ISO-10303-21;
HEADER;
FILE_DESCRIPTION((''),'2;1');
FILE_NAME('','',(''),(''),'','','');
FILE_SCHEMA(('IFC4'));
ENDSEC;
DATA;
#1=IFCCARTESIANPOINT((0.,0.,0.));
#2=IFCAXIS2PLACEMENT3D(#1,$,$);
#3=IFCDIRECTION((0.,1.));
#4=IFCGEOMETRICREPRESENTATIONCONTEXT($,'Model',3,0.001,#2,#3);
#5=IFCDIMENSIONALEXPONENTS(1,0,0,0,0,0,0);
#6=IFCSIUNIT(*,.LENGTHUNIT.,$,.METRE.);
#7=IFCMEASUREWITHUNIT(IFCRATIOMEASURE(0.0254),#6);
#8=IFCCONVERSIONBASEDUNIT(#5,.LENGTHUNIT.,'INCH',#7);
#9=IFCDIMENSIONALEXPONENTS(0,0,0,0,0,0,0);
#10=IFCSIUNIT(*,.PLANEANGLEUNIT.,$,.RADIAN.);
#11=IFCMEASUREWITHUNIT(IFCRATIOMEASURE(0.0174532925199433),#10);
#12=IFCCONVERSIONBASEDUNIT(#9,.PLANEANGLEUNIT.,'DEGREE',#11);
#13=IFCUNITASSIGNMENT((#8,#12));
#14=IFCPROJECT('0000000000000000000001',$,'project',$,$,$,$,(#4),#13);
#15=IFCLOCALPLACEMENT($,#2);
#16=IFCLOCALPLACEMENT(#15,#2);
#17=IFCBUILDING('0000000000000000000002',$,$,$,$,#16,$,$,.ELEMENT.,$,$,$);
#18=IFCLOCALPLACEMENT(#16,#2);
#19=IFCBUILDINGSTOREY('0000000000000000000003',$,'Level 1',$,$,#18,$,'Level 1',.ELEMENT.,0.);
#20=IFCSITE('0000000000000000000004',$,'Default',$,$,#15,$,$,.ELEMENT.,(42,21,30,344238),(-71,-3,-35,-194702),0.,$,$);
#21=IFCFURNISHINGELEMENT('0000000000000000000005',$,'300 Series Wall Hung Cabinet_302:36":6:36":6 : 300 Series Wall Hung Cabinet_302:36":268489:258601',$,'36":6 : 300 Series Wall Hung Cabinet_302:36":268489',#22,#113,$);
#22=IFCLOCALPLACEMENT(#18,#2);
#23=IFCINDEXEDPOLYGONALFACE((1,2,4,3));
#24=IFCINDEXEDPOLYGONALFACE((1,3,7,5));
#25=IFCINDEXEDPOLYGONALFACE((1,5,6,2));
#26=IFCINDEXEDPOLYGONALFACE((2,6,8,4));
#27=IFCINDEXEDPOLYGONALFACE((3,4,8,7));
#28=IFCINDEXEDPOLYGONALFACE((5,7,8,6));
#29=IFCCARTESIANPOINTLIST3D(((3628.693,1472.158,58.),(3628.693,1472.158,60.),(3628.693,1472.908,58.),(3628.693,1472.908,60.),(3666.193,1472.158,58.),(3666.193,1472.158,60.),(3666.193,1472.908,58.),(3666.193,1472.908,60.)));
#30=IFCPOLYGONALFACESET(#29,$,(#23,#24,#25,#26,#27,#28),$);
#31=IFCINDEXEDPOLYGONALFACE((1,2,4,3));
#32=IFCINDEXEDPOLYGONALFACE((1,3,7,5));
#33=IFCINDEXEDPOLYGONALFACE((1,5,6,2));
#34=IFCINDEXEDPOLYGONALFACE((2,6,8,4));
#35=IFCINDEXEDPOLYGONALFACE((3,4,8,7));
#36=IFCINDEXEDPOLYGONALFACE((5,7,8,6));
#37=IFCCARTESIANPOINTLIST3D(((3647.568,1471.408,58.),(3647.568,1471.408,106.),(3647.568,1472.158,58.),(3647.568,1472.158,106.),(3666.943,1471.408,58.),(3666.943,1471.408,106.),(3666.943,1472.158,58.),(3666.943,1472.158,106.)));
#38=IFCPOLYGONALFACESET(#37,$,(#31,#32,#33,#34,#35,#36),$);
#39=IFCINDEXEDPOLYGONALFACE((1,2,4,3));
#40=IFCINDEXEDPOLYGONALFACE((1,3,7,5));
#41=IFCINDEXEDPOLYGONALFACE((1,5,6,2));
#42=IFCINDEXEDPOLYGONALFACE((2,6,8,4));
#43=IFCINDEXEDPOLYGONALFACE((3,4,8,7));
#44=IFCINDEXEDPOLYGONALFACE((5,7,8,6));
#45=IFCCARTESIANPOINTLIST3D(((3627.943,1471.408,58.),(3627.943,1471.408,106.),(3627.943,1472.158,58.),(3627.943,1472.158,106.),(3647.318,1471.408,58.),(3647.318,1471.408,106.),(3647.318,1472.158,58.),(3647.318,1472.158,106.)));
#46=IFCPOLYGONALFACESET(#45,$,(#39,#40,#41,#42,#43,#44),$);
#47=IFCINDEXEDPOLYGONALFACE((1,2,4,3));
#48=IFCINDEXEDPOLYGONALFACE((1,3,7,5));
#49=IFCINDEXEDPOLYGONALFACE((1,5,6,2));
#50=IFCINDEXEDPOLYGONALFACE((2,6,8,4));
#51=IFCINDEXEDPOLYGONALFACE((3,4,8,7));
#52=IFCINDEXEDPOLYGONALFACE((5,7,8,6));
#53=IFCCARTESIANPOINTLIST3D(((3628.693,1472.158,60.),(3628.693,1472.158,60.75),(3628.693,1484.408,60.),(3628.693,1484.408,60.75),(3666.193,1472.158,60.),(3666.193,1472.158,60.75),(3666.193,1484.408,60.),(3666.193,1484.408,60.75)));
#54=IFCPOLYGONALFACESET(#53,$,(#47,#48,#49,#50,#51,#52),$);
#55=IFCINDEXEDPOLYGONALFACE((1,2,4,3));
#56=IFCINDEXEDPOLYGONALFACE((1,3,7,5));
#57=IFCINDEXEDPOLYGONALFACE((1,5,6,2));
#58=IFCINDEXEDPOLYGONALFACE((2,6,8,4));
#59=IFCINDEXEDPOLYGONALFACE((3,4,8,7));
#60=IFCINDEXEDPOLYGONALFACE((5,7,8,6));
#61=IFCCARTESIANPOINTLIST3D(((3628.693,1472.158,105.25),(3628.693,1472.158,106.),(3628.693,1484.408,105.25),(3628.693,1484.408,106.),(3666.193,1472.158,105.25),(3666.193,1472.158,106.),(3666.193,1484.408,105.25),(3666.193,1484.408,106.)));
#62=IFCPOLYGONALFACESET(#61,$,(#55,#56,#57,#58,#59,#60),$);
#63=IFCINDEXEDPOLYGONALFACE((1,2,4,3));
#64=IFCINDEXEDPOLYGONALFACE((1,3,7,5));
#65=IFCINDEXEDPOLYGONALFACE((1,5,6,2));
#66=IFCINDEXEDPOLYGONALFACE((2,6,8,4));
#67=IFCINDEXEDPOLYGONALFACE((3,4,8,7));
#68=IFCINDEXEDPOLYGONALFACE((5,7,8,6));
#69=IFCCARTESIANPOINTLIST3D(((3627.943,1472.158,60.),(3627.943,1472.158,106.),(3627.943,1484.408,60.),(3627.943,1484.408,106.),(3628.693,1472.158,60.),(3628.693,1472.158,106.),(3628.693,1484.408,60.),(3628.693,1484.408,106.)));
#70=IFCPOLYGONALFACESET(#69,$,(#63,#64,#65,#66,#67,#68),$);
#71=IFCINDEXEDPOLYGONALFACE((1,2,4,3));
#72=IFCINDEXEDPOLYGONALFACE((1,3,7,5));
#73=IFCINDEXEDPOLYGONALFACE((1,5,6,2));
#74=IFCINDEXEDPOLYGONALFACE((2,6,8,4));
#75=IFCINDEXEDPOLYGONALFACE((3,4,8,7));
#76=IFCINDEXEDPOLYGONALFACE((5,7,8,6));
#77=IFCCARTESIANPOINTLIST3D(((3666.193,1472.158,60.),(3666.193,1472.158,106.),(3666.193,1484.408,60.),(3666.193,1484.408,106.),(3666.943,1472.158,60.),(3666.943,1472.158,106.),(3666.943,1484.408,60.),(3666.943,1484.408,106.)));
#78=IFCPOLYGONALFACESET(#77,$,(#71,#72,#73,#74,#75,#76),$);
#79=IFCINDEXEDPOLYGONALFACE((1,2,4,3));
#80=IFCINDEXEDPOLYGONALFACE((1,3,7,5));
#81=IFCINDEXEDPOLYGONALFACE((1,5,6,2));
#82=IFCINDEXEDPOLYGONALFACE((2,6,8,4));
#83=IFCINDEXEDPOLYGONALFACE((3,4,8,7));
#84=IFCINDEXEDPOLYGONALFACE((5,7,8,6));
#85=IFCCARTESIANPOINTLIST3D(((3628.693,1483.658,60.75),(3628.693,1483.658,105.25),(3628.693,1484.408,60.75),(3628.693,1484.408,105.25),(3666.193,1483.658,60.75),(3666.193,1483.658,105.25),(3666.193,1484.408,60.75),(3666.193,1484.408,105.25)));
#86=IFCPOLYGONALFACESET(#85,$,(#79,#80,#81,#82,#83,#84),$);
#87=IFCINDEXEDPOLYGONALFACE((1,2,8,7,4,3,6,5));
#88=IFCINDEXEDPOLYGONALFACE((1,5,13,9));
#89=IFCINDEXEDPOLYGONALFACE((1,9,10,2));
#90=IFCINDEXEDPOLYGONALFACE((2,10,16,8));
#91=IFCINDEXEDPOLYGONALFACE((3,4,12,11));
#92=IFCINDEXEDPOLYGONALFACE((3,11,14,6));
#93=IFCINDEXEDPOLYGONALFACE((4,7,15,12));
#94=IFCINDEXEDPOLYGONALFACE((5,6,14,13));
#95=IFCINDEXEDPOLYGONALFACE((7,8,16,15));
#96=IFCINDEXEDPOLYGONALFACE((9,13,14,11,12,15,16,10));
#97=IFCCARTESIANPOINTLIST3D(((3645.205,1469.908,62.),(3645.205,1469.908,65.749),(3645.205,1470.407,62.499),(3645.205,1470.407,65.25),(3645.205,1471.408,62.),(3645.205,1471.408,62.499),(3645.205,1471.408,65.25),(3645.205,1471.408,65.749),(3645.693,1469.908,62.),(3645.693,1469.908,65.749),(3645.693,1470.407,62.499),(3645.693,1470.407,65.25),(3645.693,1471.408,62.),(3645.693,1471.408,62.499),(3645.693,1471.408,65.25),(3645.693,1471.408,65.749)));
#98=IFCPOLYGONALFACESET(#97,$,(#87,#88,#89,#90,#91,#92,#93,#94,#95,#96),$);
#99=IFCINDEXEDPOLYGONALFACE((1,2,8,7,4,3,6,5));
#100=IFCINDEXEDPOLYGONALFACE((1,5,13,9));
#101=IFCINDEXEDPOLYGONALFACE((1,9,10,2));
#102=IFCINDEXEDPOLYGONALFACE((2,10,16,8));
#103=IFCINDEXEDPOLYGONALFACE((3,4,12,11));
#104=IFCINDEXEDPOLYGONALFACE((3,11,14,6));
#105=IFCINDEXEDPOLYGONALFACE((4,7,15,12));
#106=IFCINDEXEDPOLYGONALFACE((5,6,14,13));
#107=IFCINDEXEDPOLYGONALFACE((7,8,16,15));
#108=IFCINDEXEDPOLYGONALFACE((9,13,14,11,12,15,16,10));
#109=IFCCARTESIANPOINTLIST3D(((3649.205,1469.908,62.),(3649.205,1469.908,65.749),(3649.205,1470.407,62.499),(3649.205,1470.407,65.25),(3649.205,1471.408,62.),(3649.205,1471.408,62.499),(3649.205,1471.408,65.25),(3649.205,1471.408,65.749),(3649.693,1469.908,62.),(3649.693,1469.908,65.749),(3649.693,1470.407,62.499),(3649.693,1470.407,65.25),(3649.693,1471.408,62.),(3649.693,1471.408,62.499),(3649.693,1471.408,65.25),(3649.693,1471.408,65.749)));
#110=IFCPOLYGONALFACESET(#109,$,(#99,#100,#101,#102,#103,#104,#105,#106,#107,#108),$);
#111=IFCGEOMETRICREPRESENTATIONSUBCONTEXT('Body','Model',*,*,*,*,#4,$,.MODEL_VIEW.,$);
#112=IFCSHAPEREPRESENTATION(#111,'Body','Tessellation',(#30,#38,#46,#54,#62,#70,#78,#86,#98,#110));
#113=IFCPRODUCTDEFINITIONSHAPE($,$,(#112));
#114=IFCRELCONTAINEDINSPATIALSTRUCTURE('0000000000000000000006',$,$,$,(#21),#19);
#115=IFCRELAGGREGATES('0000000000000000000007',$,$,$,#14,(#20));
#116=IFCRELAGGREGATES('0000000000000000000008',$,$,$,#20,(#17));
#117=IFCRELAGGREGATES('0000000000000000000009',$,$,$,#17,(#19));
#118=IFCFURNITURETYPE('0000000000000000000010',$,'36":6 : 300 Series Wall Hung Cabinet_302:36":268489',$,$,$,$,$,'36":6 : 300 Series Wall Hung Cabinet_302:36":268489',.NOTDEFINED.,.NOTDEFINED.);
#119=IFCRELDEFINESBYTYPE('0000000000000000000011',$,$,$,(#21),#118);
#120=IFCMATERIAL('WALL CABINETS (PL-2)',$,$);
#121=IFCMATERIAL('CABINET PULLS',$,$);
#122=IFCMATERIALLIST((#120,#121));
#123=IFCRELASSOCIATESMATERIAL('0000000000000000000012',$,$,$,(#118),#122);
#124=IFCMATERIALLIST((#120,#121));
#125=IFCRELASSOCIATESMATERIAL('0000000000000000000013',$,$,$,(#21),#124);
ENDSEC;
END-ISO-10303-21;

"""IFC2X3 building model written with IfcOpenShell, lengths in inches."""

from ifc_helpers import new_model, entity, si_unit, converted_unit, direction, frame, frame_2d, origin, origin_2d_with_axis, place, context, subcontext, project, spatial, polyline, rectangle, outline, extrude, source, transform, mapped, material, material_list, type_object, type_shapes, element, save


model = new_model("IFC2X3")

# Units and contexts
model_context = context("Model", 3, precision=0.001, world=origin(), true_north=direction((0.0, 1.0)))
body_context = subcontext(model_context, "Body", "Model", "MODEL_VIEW")
ifc_project = project(units=[converted_unit("LENGTHUNIT", "INCH", entity("IfcRatioMeasure", 0.0254), si_unit("LENGTHUNIT", "METRE"), dimensions=[1, 0, 0, 0, 0, 0, 0]), converted_unit("PLANEANGLEUNIT", "DEGREE", entity("IfcRatioMeasure", 0.0174532925199433), si_unit("PLANEANGLEUNIT", "RADIAN"), dimensions=[0, 0, 0, 0, 0, 0, 0])], contexts=[model_context])

# Site, building, storey
site_placement = place(None, origin())
site = spatial("IfcSite", under=ifc_project, at=site_placement, Name="Default", CompositionType="ELEMENT", RefLatitude=(42, 21, 30, 344238), RefLongitude=(-71, -3, -35, -194702), RefElevation=0.0)
building_placement = place(site_placement, origin())
building = spatial("IfcBuilding", under=site, at=building_placement, CompositionType="ELEMENT")
storey_placement = place(building_placement, origin())
storey = spatial("IfcBuildingStorey", under=building, at=storey_placement, Name="Level 1", LongName="Level 1", CompositionType="ELEMENT", Elevation=0.0)

# Furnishing element
ifc_material_1 = material(Name="WALL CABINETS (PL-2)")
ifc_material_2 = material(Name="CABINET PULLS")
ifc_material_list_1 = material_list([ifc_material_1, ifc_material_2])
ifc_material_list_2 = material_list([ifc_material_1, ifc_material_2])
furniture_type_1 = type_object("IfcFurnitureType", Name="36\":6 : 300 Series Wall Hung Cabinet_302:36\":268489", ElementType="36\":6 : 300 Series Wall Hung Cabinet_302:36\":268489", AssemblyPlace="NOTDEFINED", material=ifc_material_list_2)
shared_shape_1 = source(origin(), body_context, "Body", "SweptSolid", [
    extrude(rectangle(XDim=37.5, YDim=0.75, at=origin_2d_with_axis()), frame((3647.443, 1472.533, 58.0)), (0.0, 0.0, 1.0), 2.0),
    extrude(rectangle(XDim=0.75, YDim=19.375, at=frame_2d((0.0, 0.0), x_axis=(1.0, 0.0))), frame((3657.256, 1471.783, 58.0), z_axis=(0.0, 0.0, 1.0), x_axis=(0.0, 1.0, 0.0)), (0.0, 0.0, 1.0), 48.0),
    extrude(rectangle(XDim=0.75, YDim=19.375, at=frame_2d((0.0, 0.0), x_axis=(1.0, 0.0))), frame((3637.631, 1471.783, 58.0), z_axis=(0.0, 0.0, 1.0), x_axis=(0.0, 1.0, 0.0)), (0.0, 0.0, 1.0), 48.0),
    extrude(rectangle(XDim=12.25, YDim=37.5, at=frame_2d((0.0, 0.0), x_axis=(1.0, 0.0))), frame((3647.443, 1478.283, 60.0), z_axis=(0.0, 0.0, 1.0), x_axis=(0.0, 1.0, 0.0)), (0.0, 0.0, 1.0), 0.75),
    extrude(rectangle(XDim=12.25, YDim=37.5, at=origin_2d_with_axis()), frame((3647.443, 1478.283, 105.25), z_axis=(0.0, 0.0, 1.0), x_axis=(0.0, 1.0, 0.0)), (0.0, 0.0, 1.0), 0.75),
    extrude(rectangle(XDim=12.25, YDim=0.75, at=frame_2d((0.0, 0.0), x_axis=(1.0, 0.0))), frame((3628.318, 1478.283, 60.0), z_axis=(0.0, 0.0, 1.0), x_axis=(0.0, -1.0, 0.0)), (0.0, 0.0, 1.0), 46.0),
    extrude(rectangle(XDim=12.25, YDim=0.75, at=frame_2d((0.0, 0.0), x_axis=(1.0, 0.0))), frame((3666.568, 1478.283, 60.0), z_axis=(0.0, 0.0, 1.0), x_axis=(0.0, -1.0, 0.0)), (0.0, 0.0, 1.0), 46.0),
    extrude(rectangle(XDim=37.5, YDim=0.75, at=origin_2d_with_axis()), frame((3647.443, 1484.033, 60.75)), (0.0, 0.0, 1.0), 44.5),
    extrude(outline(polyline([(-0.376, 1.375), (0.625, 1.375), (0.625, 1.874), (-0.874, 1.874), (-0.874, -1.874), (0.625, -1.874), (0.625, -1.375), (-0.376, -1.375), (-0.376, 1.375)])), frame((3645.205, 1470.783, 63.874), z_axis=(1.0, 0.0, 0.0), x_axis=(0.0, 1.0, 0.0)), (0.0, 0.0, 1.0), 0.488),
    extrude(outline(polyline([(-0.376, 1.375), (0.625, 1.375), (0.625, 1.874), (-0.874, 1.874), (-0.874, -1.874), (0.625, -1.874), (0.625, -1.375), (-0.376, -1.375), (-0.376, 1.375)])), frame((3649.205, 1470.783, 63.874), z_axis=(1.0, 0.0, 0.0), x_axis=(0.0, 1.0, 0.0)), (0.0, 0.0, 1.0), 0.488),
])
type_shapes(furniture_type_1, [shared_shape_1])
furnishing_1_placement = place(building_placement, origin())
element("IfcFurnishingElement", 1, at=furnishing_1_placement, inside=storey, type_object=furniture_type_1, material=ifc_material_list_1, Name="300 Series Wall Hung Cabinet_302:36\":6:36\":6 : 300 Series Wall Hung Cabinet_302:36\":268489:258601", ObjectType="36\":6 : 300 Series Wall Hung Cabinet_302:36\":268489", context=body_context, shape_type="MappedRepresentation", body=[
    mapped(shared_shape_1, transform((0.0, 0.0, 0.0), scale=1.0)),
])

save(model, "model.ifc")
